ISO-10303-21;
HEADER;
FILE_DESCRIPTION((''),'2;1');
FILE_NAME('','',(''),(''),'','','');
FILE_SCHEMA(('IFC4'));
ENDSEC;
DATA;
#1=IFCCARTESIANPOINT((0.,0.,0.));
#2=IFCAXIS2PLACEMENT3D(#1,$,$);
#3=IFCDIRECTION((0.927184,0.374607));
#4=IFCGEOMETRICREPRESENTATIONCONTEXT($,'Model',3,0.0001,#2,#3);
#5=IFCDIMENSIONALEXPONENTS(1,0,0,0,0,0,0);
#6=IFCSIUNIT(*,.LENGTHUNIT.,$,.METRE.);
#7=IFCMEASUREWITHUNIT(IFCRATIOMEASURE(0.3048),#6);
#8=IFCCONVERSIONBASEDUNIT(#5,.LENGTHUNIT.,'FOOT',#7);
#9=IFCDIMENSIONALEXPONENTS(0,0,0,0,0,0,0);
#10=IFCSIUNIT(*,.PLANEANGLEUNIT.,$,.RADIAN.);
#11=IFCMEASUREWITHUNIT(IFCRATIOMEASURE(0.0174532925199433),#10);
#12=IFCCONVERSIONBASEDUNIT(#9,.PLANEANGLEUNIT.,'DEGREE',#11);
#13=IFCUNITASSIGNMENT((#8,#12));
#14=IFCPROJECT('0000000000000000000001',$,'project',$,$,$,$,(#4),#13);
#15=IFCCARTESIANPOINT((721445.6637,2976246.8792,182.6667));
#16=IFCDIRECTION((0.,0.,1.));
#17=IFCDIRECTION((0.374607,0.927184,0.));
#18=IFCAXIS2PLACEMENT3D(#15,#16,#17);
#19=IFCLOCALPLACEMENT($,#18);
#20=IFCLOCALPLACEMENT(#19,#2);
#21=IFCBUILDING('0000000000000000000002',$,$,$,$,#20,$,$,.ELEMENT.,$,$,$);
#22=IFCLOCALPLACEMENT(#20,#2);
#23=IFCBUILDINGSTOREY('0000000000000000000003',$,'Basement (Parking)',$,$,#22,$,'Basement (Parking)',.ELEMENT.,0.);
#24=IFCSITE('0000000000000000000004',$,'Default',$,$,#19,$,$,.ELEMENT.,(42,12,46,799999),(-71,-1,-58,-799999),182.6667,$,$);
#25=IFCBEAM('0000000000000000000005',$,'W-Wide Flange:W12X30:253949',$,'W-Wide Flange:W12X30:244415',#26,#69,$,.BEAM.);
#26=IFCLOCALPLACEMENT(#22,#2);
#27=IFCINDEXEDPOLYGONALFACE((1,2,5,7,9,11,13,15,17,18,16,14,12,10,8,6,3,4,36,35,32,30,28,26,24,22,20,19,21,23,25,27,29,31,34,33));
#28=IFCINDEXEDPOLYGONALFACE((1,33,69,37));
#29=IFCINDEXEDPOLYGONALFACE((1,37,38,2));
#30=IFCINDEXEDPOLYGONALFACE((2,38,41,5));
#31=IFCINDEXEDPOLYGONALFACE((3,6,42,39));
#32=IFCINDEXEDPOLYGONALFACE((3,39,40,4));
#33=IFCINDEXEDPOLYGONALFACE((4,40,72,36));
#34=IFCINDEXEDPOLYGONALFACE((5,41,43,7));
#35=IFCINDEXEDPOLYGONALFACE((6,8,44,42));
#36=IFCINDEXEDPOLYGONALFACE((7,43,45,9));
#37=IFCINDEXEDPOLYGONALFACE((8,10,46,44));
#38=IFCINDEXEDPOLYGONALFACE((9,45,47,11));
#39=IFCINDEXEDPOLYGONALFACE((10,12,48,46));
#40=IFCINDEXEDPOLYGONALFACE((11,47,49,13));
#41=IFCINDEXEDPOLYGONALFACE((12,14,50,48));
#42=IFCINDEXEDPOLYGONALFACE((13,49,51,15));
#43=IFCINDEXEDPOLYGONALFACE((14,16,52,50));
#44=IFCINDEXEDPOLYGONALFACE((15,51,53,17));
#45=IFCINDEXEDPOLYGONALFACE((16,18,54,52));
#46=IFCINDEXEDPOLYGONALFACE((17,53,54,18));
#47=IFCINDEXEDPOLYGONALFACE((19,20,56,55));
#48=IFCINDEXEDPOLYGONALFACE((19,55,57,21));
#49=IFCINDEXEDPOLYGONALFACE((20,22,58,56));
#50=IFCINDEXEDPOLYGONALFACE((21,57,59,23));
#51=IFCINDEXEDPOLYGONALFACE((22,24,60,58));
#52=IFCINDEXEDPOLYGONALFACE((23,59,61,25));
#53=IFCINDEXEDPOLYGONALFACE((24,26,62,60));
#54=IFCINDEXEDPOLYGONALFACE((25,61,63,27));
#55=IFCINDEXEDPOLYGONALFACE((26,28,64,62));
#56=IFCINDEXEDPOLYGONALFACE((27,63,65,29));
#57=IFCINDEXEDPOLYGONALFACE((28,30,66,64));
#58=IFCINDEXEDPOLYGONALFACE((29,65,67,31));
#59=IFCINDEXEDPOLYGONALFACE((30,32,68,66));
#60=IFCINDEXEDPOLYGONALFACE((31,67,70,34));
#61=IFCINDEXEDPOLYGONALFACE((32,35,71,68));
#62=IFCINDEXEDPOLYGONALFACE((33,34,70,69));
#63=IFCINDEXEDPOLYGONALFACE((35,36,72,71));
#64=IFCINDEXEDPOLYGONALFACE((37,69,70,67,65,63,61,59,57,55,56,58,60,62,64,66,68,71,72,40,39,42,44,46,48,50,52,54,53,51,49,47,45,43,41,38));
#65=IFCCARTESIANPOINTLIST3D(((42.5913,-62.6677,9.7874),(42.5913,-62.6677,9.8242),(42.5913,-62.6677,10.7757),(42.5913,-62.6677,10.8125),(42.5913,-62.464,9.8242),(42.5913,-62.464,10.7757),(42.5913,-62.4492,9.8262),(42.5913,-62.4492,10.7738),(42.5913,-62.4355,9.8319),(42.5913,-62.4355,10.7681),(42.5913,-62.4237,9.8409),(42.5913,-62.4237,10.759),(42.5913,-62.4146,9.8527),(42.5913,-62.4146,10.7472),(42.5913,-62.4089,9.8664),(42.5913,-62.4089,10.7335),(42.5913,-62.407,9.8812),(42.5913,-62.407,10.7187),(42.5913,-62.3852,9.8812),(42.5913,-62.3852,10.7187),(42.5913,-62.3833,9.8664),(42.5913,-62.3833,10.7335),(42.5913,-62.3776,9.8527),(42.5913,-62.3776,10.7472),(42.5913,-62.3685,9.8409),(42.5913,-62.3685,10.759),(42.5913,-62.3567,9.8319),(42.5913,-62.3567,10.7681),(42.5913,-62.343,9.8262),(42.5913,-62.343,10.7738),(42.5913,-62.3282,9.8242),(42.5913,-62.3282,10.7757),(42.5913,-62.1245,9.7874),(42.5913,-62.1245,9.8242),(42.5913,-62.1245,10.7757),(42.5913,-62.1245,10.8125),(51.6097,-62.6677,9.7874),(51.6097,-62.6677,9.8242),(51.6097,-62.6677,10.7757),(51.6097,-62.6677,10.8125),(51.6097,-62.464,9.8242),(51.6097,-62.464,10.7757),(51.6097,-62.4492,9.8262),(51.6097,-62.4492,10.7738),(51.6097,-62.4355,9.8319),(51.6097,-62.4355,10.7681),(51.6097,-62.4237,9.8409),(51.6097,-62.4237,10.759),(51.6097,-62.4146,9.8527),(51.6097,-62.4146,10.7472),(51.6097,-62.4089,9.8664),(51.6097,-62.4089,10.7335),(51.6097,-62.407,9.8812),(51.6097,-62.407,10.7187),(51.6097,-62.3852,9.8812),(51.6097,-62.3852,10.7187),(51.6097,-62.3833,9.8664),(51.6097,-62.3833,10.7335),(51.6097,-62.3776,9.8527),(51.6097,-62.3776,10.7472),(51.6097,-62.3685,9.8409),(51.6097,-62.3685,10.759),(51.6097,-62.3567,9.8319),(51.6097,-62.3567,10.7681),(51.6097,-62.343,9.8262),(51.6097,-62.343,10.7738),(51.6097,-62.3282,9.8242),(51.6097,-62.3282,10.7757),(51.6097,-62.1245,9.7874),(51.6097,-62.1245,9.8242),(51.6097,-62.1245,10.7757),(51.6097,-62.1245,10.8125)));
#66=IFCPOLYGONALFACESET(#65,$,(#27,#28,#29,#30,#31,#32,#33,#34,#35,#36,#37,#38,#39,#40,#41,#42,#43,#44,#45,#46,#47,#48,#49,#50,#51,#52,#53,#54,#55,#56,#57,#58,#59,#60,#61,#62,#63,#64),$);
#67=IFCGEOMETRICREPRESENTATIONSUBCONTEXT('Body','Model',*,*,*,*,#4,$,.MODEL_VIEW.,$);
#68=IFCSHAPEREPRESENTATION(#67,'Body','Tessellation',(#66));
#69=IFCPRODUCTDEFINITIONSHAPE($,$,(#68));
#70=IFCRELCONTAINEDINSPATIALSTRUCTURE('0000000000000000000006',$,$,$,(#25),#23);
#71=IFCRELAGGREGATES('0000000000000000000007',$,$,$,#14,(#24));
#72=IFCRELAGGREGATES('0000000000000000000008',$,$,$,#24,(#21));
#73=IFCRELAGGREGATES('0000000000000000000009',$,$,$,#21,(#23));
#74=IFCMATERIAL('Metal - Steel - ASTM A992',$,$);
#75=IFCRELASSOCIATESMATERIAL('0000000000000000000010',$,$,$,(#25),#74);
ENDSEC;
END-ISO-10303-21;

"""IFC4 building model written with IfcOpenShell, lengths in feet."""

from ifc_helpers import new_model, entity, si_unit, converted_unit, direction, frame, frame_2d, origin, place, context, subcontext, project, spatial, i_section, extrude, material, element, save


model = new_model("IFC4")

# Units and contexts
model_context = context("Model", 3, precision=0.0001, world=origin(), true_north=direction((0.927184, 0.374607)))
body_context = subcontext(model_context, "Body", "Model", "MODEL_VIEW")
ifc_project = project(units=[converted_unit("LENGTHUNIT", "FOOT", entity("IfcRatioMeasure", 0.3048), si_unit("LENGTHUNIT", "METRE"), dimensions=[1, 0, 0, 0, 0, 0, 0]), converted_unit("PLANEANGLEUNIT", "DEGREE", entity("IfcRatioMeasure", 0.0174532925199433), si_unit("PLANEANGLEUNIT", "RADIAN"), dimensions=[0, 0, 0, 0, 0, 0, 0])], contexts=[model_context])

# Site, building, storey
site_placement = place(None, frame((721445.6637, 2976246.8792, 182.6667), z_axis=(0.0, 0.0, 1.0), x_axis=(0.374607, 0.927184, 0.0)))
site = spatial("IfcSite", under=ifc_project, at=site_placement, Name="Default", CompositionType="ELEMENT", RefLatitude=(42, 12, 46, 799999), RefLongitude=(-71, -1, -58, -799999), RefElevation=182.6667)
building_placement = place(site_placement, origin())
building = spatial("IfcBuilding", under=site, at=building_placement, CompositionType="ELEMENT")
storey_placement = place(building_placement, origin())
storey = spatial("IfcBuildingStorey", under=building, at=storey_placement, Name="Basement (Parking)", LongName="Basement (Parking)", CompositionType="ELEMENT", Elevation=0.0)

# Shared definitions
ifc_material_1 = material(Name="Metal - Steel - ASTM A992")

# Beam
beam_1_placement = place(storey_placement, frame((42.008, -62.3961, 10.8125)))
element("IfcBeam", 1, at=beam_1_placement, inside=storey, material=ifc_material_1, Name="W-Wide Flange:W12X30:253949", ObjectType="W-Wide Flange:W12X30:244415", PredefinedType="BEAM", context=body_context, shape_type="SweptSolid", body=[
    extrude(i_section(OverallWidth=0.5433, OverallDepth=1.0251, WebThickness=0.0218, FlangeThickness=0.0368, FilletRadius=0.057, at=frame_2d((0.0, 0.0), x_axis=(0.0, 1.0))), frame((0.5833, 0.0, -0.5125), z_axis=(1.0, 0.0, 0.0), x_axis=(0.0, 0.0, -1.0)), (0.0, 0.0, 1.0), 9.0184),
])

save(model, "model.ifc")
